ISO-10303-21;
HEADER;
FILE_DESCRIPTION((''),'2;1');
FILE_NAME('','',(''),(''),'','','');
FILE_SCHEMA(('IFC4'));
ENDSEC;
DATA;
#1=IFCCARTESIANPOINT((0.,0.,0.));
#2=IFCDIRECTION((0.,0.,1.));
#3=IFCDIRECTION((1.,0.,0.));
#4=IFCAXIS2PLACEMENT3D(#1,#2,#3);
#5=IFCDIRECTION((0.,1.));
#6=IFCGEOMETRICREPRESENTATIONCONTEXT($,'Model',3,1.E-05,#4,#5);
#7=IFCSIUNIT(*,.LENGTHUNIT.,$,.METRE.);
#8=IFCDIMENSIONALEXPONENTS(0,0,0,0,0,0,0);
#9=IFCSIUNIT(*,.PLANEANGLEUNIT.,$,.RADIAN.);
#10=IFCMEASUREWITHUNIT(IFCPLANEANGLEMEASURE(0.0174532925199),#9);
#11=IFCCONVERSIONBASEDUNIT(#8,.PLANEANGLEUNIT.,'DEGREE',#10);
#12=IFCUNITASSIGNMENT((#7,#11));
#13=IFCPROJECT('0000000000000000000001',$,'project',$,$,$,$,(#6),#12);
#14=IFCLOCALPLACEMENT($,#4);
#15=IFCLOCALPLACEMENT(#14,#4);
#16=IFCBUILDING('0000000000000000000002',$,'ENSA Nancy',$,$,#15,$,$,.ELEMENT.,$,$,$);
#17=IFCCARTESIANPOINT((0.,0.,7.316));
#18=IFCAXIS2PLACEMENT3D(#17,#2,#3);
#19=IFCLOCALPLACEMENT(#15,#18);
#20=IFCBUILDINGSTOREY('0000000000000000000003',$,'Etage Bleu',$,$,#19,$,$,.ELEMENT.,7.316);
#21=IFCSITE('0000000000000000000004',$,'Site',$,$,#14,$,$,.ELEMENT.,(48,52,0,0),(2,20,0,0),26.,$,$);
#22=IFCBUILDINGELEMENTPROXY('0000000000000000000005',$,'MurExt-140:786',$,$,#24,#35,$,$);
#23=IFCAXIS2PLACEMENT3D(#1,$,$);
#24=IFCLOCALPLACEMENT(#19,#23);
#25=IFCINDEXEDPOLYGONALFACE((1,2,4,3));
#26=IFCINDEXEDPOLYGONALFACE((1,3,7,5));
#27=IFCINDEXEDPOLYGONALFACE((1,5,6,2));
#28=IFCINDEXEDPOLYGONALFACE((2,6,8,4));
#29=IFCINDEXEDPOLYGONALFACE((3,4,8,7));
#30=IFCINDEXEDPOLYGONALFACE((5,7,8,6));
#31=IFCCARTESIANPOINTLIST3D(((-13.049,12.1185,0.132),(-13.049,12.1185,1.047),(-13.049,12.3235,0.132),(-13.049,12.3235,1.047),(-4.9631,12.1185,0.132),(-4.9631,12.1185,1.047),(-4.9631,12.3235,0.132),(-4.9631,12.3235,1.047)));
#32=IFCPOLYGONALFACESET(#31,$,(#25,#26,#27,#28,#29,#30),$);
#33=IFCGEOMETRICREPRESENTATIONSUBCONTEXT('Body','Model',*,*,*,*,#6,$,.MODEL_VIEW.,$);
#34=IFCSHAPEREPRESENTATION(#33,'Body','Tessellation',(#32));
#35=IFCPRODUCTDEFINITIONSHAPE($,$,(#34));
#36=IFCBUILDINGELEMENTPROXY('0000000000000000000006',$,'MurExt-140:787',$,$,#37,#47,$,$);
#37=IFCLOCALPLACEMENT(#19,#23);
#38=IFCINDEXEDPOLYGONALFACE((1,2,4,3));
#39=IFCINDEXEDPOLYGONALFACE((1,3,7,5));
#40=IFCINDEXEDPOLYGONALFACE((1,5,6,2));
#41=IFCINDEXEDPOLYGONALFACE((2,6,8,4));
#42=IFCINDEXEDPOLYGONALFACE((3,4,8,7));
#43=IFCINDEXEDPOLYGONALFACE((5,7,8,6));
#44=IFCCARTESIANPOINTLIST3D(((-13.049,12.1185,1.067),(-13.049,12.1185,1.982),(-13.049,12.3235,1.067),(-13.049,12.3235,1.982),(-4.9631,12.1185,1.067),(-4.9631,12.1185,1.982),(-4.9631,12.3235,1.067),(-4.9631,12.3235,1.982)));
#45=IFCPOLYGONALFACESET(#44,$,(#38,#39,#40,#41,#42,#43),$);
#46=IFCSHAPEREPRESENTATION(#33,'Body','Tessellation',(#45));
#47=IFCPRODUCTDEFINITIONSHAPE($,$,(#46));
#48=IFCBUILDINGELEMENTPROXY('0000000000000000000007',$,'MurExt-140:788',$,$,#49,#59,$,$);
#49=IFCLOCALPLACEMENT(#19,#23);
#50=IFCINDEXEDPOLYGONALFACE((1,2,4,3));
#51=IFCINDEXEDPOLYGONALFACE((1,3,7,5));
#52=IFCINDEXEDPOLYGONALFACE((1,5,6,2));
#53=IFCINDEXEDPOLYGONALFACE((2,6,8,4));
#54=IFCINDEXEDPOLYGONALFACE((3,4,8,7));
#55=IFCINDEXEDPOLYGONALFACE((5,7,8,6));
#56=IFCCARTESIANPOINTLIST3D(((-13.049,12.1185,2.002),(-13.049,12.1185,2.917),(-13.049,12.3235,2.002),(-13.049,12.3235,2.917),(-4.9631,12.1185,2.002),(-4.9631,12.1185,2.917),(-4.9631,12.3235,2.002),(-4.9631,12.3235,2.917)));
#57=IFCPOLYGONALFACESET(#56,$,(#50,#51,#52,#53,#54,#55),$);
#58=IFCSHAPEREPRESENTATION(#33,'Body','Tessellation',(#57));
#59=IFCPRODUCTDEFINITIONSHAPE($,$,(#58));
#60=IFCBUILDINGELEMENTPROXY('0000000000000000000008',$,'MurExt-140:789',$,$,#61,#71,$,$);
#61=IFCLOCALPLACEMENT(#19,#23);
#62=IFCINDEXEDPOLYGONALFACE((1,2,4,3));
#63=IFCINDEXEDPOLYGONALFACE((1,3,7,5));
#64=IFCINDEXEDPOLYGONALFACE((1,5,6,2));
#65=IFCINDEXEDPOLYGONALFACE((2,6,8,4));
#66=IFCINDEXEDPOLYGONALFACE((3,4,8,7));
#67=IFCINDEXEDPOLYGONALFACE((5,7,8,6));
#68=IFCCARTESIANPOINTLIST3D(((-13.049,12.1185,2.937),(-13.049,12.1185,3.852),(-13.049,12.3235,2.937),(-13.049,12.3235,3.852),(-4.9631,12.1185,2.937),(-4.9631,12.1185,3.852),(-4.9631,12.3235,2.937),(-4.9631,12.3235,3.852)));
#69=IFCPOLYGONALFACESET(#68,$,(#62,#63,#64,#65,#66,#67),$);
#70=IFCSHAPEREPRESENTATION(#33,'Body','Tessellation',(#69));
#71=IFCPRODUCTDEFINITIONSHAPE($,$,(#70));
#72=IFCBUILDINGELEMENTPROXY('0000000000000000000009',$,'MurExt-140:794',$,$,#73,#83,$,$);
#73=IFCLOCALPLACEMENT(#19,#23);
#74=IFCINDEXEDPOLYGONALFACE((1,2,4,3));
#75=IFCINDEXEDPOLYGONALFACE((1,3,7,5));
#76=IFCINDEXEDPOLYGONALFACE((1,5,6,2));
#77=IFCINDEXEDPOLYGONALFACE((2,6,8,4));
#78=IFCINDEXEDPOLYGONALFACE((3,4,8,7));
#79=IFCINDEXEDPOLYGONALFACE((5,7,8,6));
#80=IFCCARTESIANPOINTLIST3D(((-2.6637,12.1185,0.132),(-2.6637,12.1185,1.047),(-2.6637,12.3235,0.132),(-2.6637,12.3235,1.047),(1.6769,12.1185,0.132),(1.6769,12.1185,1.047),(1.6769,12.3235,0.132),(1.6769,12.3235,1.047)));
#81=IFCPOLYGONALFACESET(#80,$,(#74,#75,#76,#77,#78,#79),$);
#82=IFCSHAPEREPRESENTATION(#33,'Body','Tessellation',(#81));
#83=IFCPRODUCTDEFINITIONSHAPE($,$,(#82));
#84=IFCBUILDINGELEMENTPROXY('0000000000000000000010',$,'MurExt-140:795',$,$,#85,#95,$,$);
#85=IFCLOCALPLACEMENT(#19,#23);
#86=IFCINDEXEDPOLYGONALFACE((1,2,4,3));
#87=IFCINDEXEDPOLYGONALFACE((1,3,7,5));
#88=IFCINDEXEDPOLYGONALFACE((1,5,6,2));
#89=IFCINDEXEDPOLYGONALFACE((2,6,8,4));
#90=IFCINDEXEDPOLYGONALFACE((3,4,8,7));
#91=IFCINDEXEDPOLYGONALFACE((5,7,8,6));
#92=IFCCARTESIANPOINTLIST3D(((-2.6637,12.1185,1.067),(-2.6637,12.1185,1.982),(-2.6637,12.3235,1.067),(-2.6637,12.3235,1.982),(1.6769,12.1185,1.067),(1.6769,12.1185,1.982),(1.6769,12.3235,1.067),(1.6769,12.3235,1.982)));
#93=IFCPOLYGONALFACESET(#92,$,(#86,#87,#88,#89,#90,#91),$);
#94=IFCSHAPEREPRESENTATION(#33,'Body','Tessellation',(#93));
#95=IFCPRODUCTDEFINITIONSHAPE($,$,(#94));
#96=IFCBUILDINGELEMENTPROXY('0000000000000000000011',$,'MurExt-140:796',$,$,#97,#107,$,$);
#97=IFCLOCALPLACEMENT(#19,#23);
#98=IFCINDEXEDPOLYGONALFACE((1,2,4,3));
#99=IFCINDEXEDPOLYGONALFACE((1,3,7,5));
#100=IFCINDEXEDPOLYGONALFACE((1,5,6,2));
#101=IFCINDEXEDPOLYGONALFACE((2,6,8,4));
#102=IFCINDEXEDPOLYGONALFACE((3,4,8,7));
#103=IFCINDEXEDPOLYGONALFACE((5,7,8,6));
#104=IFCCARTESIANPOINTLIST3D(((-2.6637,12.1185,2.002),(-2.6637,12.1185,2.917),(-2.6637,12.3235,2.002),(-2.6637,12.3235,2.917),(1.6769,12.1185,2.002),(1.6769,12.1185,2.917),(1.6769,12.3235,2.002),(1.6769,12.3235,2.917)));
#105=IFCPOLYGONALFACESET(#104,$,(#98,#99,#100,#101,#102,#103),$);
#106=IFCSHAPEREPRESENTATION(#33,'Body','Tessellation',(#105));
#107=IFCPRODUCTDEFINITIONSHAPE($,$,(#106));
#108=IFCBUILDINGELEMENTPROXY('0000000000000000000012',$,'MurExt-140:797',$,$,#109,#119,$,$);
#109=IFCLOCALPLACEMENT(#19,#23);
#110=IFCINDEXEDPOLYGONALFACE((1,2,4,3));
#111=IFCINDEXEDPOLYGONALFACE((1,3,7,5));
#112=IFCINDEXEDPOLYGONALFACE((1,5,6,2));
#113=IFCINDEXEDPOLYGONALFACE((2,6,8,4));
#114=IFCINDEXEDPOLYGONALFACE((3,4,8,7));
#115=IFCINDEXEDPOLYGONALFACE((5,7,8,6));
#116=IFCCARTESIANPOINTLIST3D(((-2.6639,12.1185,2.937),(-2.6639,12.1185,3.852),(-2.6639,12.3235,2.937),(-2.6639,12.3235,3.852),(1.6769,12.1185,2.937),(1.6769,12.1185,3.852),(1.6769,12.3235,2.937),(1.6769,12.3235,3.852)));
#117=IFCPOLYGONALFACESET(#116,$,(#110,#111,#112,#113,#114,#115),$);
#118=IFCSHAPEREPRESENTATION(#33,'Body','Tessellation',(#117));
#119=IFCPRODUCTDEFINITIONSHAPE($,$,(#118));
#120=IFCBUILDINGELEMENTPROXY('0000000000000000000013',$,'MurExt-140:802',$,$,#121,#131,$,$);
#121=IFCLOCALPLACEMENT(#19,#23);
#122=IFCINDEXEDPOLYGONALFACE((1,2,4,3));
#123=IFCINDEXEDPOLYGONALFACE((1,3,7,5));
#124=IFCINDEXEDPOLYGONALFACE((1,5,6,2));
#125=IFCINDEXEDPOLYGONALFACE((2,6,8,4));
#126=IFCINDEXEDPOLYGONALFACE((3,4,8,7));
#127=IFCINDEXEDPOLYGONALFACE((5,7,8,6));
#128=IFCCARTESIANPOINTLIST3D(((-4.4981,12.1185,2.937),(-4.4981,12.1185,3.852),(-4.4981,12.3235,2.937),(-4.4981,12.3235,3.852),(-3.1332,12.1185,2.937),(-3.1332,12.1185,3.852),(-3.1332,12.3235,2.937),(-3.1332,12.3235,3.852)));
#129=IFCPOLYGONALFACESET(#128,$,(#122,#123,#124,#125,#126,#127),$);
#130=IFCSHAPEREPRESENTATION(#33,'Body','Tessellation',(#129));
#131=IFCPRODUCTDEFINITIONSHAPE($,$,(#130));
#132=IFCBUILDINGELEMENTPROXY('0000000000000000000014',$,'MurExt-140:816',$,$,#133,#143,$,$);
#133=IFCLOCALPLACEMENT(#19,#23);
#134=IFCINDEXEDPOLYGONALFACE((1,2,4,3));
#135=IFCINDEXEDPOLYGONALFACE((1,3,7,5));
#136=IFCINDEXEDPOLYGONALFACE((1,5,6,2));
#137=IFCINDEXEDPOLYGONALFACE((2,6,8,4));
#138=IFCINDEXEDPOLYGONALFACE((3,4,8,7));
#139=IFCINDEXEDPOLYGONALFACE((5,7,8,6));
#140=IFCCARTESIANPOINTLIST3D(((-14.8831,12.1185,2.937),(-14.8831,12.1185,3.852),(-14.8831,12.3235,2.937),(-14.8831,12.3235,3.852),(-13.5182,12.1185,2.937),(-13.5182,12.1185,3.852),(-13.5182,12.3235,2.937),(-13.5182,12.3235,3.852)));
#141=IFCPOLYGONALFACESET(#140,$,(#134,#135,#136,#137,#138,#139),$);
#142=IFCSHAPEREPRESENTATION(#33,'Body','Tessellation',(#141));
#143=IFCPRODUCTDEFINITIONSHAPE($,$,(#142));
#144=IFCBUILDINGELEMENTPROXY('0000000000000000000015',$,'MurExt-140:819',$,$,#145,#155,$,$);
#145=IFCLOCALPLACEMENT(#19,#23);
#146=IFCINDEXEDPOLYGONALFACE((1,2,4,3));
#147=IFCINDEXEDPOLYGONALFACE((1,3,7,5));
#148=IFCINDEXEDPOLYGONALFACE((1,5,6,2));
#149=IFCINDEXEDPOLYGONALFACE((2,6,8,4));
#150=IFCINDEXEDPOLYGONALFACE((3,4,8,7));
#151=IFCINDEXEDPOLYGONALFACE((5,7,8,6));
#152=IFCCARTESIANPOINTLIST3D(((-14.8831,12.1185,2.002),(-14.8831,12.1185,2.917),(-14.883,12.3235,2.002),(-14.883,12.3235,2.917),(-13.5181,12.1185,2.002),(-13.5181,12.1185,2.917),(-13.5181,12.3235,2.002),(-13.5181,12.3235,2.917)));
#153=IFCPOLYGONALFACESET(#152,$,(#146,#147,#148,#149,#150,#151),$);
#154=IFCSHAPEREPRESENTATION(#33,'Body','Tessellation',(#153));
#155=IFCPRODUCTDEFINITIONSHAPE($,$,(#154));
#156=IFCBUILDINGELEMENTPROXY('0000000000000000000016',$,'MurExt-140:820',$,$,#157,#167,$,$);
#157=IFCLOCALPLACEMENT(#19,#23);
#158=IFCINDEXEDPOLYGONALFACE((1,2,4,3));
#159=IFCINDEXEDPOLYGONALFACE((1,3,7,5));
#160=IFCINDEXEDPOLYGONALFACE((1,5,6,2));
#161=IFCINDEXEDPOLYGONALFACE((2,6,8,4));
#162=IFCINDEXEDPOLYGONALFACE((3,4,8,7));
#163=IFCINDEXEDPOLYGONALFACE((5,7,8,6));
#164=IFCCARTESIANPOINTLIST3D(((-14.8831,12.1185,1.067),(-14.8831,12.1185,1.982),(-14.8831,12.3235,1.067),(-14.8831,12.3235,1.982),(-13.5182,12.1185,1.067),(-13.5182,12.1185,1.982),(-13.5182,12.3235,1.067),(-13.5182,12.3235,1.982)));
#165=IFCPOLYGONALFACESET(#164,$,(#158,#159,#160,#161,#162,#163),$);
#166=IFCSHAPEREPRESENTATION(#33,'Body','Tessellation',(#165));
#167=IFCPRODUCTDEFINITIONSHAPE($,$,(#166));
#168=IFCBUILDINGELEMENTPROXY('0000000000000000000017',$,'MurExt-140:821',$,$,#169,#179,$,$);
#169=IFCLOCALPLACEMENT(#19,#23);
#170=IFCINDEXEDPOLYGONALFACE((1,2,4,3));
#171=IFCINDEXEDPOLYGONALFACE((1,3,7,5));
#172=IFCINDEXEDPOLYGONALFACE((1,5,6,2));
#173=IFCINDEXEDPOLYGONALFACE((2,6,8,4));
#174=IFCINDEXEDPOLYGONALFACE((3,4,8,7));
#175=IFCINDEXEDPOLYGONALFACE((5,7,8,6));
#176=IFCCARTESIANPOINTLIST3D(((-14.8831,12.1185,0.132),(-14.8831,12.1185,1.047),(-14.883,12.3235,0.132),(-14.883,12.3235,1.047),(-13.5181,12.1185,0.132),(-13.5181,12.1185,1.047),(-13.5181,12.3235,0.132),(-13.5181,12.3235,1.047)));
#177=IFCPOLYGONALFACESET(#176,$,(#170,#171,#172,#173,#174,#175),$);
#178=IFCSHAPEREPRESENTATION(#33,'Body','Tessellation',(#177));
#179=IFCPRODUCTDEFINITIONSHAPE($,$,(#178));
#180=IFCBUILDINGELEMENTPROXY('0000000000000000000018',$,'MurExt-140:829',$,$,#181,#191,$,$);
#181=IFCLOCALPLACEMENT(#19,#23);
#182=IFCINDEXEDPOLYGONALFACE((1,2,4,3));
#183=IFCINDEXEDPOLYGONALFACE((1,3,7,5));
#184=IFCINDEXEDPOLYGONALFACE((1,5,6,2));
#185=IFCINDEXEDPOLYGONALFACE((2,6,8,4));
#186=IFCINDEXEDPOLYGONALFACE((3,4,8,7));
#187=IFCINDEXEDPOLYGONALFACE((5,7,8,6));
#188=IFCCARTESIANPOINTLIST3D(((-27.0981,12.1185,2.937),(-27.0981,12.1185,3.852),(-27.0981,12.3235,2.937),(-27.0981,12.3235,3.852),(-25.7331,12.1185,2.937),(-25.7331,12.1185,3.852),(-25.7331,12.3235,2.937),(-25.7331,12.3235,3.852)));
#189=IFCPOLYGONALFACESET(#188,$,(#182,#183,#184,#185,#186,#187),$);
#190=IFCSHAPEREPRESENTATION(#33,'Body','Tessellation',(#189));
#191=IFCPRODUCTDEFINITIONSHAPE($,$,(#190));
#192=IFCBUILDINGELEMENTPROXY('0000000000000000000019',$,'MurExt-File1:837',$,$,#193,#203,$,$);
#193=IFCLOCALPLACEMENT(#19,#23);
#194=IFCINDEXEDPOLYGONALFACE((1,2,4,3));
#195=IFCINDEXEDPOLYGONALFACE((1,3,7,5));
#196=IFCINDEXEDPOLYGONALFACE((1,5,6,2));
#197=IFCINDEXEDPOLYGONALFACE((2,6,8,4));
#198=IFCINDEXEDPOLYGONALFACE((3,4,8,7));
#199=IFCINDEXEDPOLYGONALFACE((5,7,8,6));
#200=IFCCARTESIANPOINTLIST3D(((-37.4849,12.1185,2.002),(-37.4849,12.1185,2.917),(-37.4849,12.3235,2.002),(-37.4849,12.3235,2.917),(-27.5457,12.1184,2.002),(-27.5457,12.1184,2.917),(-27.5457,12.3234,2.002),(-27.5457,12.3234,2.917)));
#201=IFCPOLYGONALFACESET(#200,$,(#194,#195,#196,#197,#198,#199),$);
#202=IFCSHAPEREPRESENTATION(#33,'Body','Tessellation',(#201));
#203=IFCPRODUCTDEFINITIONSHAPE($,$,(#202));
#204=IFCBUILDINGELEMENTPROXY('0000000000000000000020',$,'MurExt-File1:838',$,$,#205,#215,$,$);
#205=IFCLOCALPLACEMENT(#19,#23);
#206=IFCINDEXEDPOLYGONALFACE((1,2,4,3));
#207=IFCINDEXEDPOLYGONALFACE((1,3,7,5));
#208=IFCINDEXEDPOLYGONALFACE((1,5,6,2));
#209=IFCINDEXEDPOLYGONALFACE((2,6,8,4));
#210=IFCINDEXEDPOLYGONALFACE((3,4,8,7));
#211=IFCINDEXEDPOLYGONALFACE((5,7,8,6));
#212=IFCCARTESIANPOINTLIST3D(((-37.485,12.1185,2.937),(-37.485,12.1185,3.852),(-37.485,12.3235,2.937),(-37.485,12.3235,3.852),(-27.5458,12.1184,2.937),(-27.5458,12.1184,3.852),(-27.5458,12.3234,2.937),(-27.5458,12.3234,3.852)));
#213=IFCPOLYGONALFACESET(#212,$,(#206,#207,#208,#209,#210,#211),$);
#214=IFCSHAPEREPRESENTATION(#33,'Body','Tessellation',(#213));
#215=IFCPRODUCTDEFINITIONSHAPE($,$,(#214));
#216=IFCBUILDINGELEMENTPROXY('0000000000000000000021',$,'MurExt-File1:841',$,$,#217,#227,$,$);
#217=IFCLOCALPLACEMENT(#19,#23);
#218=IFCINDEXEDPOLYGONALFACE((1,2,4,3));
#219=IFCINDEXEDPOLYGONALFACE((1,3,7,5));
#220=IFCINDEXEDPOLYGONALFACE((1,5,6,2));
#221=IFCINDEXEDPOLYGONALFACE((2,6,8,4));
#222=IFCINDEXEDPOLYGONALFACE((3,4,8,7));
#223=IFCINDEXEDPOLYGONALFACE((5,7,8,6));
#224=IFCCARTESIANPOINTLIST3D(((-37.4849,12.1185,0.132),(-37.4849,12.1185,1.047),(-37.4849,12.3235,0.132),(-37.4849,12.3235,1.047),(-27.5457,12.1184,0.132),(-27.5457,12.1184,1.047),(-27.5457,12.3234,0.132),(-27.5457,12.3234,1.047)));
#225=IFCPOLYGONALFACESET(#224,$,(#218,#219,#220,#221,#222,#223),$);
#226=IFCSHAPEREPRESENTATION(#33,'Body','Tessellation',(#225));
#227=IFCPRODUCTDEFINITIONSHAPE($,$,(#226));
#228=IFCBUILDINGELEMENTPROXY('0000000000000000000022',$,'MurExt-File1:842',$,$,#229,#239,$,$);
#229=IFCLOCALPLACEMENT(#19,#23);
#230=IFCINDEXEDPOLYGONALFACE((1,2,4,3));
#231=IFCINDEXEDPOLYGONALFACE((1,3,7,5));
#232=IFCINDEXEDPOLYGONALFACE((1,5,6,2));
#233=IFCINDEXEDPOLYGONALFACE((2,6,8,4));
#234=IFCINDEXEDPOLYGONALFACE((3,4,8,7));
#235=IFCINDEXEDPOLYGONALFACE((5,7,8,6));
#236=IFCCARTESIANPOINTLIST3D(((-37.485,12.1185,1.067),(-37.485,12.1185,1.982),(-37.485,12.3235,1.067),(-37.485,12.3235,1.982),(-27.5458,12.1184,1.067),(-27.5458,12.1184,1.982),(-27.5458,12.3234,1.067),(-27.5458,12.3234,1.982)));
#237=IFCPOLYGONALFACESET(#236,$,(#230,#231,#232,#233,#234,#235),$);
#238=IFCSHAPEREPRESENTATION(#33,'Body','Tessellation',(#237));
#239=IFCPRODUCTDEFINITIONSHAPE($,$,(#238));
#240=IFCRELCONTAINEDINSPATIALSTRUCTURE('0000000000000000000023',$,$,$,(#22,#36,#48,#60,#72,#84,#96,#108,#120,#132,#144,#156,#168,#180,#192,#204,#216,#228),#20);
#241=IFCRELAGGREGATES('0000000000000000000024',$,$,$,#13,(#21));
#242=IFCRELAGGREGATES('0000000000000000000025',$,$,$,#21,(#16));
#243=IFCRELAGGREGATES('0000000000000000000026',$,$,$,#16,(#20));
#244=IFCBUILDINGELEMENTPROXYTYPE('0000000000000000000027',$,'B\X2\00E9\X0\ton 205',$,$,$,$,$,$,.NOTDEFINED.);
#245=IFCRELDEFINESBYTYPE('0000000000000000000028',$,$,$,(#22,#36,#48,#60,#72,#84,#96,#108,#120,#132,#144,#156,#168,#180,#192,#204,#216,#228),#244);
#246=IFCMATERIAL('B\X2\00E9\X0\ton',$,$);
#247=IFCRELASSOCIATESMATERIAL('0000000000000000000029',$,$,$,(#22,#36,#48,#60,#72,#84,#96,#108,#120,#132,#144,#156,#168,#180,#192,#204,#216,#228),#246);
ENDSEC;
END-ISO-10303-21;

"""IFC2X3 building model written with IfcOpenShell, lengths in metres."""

from ifc_helpers import new_model, entity, si_unit, converted_unit, direction, frame, origin_with_axes, place, context, subcontext, project, spatial, polyline, outline, extrude, material, type_object, element, save


model = new_model("IFC2X3")

# Units and contexts
model_context = context("Model", 3, precision=1e-05, world=origin_with_axes(), true_north=direction((0.0, 1.0)))
body_context = subcontext(model_context, "Body", "Model", "MODEL_VIEW")
ifc_project = project(units=[si_unit("LENGTHUNIT", "METRE"), converted_unit("PLANEANGLEUNIT", "DEGREE", entity("IfcPlaneAngleMeasure", 0.0174532925199), si_unit("PLANEANGLEUNIT", "RADIAN"), dimensions=[0, 0, 0, 0, 0, 0, 0])], contexts=[model_context])

# Site, building, storey
site_placement = place(None, origin_with_axes())
site = spatial("IfcSite", under=ifc_project, at=site_placement, Name="Site", CompositionType="ELEMENT", RefLatitude=(48, 52, 0, 0), RefLongitude=(2, 20, 0, 0), RefElevation=26.0)
building_placement = place(site_placement, origin_with_axes())
building = spatial("IfcBuilding", under=site, at=building_placement, Name="ENSA Nancy", CompositionType="ELEMENT")
storey_placement = place(building_placement, frame((0.0, 0.0, 7.316), z_axis=(0.0, 0.0, 1.0), x_axis=(1.0, 0.0, 0.0)))
storey = spatial("IfcBuildingStorey", under=building, at=storey_placement, Name="Etage Bleu", CompositionType="ELEMENT", Elevation=7.316)

# Building element proxies
ifc_material = material(Name="Béton")
building_element_proxy_type_1 = type_object("IfcBuildingElementProxyType", Name="Béton 205", PredefinedType="NOTDEFINED")
for number, where, z_axis, x_axis, name in (
    (1, (-13.049, 12.3235, 0.132), (0.0, 0.0, 1.0), (1.0, 0.0, 0.0), "MurExt-140:786"),
    (2, (-13.049, 12.3235, 1.067), (0.0, 0.0, 1.0), (1.0, 0.0, 0.0), "MurExt-140:787"),
    (3, (-13.049, 12.3235, 2.002), (0.0, 0.0, 1.0), (1.0, 0.0, 0.0), "MurExt-140:788"),
    (4, (-13.049, 12.3235, 2.937), (0.0, 0.0, 1.0), (1.0, 0.0, 0.0), "MurExt-140:789"),
):
    element("IfcBuildingElementProxy", number, at=place(storey_placement, frame(where, z_axis=z_axis, x_axis=x_axis)), inside=storey, type_object=building_element_proxy_type_1, material=ifc_material, Name=name, context=body_context, shape_type="SweptSolid", body=[
        extrude(outline(polyline([(0.0, -0.205), (8.0859, -0.205), (8.0859, 0.0), (0.0, 0.0), (0.0, -0.205)])), origin_with_axes(), (0.0, 0.0, 1.0), 0.915),
    ])
for number, where, z_axis, x_axis, name in (
    (5, (-2.6637, 12.3235, 0.132), (0.0, 0.0, 1.0), (1.0, 0.0, 0.0), "MurExt-140:794"),
    (6, (-2.6637, 12.3235, 1.067), (0.0, 0.0, 1.0), (1.0, 0.0, 0.0), "MurExt-140:795"),
    (7, (-2.6637, 12.3235, 2.002), (0.0, 0.0, 1.0), (1.0, 0.0, 0.0), "MurExt-140:796"),
):
    element("IfcBuildingElementProxy", number, at=place(storey_placement, frame(where, z_axis=z_axis, x_axis=x_axis)), inside=storey, type_object=building_element_proxy_type_1, material=ifc_material, Name=name, context=body_context, shape_type="SweptSolid", body=[
        extrude(outline(polyline([(0.0, -0.205), (4.3406, -0.205), (4.3406, 0.0), (0.0, 0.0), (0.0, -0.205)])), origin_with_axes(), (0.0, 0.0, 1.0), 0.915),
    ])
proxy_1_placement = place(storey_placement, frame((-2.6639, 12.3235, 2.937), z_axis=(0.0, 0.0, 1.0), x_axis=(1.0, 0.0, 0.0)))
element("IfcBuildingElementProxy", 8, at=proxy_1_placement, inside=storey, type_object=building_element_proxy_type_1, material=ifc_material, Name="MurExt-140:797", context=body_context, shape_type="SweptSolid", body=[
    extrude(outline(polyline([(0.0, -0.205), (4.3408, -0.205), (4.3408, 0.0), (0.0, 0.0), (0.0, -0.205)])), origin_with_axes(), (0.0, 0.0, 1.0), 0.915),
])
for number, where, z_axis, x_axis, name in (
    (9, (-4.4981, 12.3235, 2.937), (0.0, 0.0, 1.0), (1.0, -0.000005, 0.0), "MurExt-140:802"),
    (10, (-14.8831, 12.3235, 2.937), (0.0, 0.0, 1.0), (1.0, -0.000005, 0.0), "MurExt-140:816"),
    (11, (-14.883, 12.3235, 2.002), (0.0, 0.0, 1.0), (1.0, -0.000005, 0.0), "MurExt-140:819"),
    (12, (-14.8831, 12.3235, 1.067), (0.0, 0.0, 1.0), (1.0, -0.000005, 0.0), "MurExt-140:820"),
    (13, (-14.883, 12.3235, 0.132), (0.0, 0.0, 1.0), (1.0, -0.000005, 0.0), "MurExt-140:821"),
    (14, (-27.0981, 12.3235, 2.937), (0.0, 0.0, 1.0), (1.0, -0.000005, 0.0), "MurExt-140:829"),
):
    element("IfcBuildingElementProxy", number, at=place(storey_placement, frame(where, z_axis=z_axis, x_axis=x_axis)), inside=storey, type_object=building_element_proxy_type_1, material=ifc_material, Name=name, context=body_context, shape_type="SweptSolid", body=[
        extrude(outline(polyline([(0.0, -0.205), (1.3649, -0.205), (1.3649, 0.0), (0.0, 0.0), (0.0, -0.205)])), origin_with_axes(), (0.0, 0.0, 1.0), 0.915),
    ])
for number, where, z_axis, x_axis, name in (
    (15, (-37.4849, 12.3235, 2.002), (0.0, 0.0, 1.0), (1.0, -0.000005, 0.0), "MurExt-File1:837"),
    (16, (-37.485, 12.3235, 2.937), (0.0, 0.0, 1.0), (1.0, -0.000005, 0.0), "MurExt-File1:838"),
    (17, (-37.4849, 12.3235, 0.132), (0.0, 0.0, 1.0), (1.0, -0.000005, 0.0), "MurExt-File1:841"),
    (18, (-37.485, 12.3235, 1.067), (0.0, 0.0, 1.0), (1.0, -0.000005, 0.0), "MurExt-File1:842"),
):
    element("IfcBuildingElementProxy", number, at=place(storey_placement, frame(where, z_axis=z_axis, x_axis=x_axis)), inside=storey, type_object=building_element_proxy_type_1, material=ifc_material, Name=name, context=body_context, shape_type="SweptSolid", body=[
        extrude(outline(polyline([(0.0, -0.205), (9.9392, -0.205), (9.9392, 0.0), (0.0, 0.0), (0.0, -0.205)])), origin_with_axes(), (0.0, 0.0, 1.0), 0.915),
    ])

save(model, "model.ifc")
